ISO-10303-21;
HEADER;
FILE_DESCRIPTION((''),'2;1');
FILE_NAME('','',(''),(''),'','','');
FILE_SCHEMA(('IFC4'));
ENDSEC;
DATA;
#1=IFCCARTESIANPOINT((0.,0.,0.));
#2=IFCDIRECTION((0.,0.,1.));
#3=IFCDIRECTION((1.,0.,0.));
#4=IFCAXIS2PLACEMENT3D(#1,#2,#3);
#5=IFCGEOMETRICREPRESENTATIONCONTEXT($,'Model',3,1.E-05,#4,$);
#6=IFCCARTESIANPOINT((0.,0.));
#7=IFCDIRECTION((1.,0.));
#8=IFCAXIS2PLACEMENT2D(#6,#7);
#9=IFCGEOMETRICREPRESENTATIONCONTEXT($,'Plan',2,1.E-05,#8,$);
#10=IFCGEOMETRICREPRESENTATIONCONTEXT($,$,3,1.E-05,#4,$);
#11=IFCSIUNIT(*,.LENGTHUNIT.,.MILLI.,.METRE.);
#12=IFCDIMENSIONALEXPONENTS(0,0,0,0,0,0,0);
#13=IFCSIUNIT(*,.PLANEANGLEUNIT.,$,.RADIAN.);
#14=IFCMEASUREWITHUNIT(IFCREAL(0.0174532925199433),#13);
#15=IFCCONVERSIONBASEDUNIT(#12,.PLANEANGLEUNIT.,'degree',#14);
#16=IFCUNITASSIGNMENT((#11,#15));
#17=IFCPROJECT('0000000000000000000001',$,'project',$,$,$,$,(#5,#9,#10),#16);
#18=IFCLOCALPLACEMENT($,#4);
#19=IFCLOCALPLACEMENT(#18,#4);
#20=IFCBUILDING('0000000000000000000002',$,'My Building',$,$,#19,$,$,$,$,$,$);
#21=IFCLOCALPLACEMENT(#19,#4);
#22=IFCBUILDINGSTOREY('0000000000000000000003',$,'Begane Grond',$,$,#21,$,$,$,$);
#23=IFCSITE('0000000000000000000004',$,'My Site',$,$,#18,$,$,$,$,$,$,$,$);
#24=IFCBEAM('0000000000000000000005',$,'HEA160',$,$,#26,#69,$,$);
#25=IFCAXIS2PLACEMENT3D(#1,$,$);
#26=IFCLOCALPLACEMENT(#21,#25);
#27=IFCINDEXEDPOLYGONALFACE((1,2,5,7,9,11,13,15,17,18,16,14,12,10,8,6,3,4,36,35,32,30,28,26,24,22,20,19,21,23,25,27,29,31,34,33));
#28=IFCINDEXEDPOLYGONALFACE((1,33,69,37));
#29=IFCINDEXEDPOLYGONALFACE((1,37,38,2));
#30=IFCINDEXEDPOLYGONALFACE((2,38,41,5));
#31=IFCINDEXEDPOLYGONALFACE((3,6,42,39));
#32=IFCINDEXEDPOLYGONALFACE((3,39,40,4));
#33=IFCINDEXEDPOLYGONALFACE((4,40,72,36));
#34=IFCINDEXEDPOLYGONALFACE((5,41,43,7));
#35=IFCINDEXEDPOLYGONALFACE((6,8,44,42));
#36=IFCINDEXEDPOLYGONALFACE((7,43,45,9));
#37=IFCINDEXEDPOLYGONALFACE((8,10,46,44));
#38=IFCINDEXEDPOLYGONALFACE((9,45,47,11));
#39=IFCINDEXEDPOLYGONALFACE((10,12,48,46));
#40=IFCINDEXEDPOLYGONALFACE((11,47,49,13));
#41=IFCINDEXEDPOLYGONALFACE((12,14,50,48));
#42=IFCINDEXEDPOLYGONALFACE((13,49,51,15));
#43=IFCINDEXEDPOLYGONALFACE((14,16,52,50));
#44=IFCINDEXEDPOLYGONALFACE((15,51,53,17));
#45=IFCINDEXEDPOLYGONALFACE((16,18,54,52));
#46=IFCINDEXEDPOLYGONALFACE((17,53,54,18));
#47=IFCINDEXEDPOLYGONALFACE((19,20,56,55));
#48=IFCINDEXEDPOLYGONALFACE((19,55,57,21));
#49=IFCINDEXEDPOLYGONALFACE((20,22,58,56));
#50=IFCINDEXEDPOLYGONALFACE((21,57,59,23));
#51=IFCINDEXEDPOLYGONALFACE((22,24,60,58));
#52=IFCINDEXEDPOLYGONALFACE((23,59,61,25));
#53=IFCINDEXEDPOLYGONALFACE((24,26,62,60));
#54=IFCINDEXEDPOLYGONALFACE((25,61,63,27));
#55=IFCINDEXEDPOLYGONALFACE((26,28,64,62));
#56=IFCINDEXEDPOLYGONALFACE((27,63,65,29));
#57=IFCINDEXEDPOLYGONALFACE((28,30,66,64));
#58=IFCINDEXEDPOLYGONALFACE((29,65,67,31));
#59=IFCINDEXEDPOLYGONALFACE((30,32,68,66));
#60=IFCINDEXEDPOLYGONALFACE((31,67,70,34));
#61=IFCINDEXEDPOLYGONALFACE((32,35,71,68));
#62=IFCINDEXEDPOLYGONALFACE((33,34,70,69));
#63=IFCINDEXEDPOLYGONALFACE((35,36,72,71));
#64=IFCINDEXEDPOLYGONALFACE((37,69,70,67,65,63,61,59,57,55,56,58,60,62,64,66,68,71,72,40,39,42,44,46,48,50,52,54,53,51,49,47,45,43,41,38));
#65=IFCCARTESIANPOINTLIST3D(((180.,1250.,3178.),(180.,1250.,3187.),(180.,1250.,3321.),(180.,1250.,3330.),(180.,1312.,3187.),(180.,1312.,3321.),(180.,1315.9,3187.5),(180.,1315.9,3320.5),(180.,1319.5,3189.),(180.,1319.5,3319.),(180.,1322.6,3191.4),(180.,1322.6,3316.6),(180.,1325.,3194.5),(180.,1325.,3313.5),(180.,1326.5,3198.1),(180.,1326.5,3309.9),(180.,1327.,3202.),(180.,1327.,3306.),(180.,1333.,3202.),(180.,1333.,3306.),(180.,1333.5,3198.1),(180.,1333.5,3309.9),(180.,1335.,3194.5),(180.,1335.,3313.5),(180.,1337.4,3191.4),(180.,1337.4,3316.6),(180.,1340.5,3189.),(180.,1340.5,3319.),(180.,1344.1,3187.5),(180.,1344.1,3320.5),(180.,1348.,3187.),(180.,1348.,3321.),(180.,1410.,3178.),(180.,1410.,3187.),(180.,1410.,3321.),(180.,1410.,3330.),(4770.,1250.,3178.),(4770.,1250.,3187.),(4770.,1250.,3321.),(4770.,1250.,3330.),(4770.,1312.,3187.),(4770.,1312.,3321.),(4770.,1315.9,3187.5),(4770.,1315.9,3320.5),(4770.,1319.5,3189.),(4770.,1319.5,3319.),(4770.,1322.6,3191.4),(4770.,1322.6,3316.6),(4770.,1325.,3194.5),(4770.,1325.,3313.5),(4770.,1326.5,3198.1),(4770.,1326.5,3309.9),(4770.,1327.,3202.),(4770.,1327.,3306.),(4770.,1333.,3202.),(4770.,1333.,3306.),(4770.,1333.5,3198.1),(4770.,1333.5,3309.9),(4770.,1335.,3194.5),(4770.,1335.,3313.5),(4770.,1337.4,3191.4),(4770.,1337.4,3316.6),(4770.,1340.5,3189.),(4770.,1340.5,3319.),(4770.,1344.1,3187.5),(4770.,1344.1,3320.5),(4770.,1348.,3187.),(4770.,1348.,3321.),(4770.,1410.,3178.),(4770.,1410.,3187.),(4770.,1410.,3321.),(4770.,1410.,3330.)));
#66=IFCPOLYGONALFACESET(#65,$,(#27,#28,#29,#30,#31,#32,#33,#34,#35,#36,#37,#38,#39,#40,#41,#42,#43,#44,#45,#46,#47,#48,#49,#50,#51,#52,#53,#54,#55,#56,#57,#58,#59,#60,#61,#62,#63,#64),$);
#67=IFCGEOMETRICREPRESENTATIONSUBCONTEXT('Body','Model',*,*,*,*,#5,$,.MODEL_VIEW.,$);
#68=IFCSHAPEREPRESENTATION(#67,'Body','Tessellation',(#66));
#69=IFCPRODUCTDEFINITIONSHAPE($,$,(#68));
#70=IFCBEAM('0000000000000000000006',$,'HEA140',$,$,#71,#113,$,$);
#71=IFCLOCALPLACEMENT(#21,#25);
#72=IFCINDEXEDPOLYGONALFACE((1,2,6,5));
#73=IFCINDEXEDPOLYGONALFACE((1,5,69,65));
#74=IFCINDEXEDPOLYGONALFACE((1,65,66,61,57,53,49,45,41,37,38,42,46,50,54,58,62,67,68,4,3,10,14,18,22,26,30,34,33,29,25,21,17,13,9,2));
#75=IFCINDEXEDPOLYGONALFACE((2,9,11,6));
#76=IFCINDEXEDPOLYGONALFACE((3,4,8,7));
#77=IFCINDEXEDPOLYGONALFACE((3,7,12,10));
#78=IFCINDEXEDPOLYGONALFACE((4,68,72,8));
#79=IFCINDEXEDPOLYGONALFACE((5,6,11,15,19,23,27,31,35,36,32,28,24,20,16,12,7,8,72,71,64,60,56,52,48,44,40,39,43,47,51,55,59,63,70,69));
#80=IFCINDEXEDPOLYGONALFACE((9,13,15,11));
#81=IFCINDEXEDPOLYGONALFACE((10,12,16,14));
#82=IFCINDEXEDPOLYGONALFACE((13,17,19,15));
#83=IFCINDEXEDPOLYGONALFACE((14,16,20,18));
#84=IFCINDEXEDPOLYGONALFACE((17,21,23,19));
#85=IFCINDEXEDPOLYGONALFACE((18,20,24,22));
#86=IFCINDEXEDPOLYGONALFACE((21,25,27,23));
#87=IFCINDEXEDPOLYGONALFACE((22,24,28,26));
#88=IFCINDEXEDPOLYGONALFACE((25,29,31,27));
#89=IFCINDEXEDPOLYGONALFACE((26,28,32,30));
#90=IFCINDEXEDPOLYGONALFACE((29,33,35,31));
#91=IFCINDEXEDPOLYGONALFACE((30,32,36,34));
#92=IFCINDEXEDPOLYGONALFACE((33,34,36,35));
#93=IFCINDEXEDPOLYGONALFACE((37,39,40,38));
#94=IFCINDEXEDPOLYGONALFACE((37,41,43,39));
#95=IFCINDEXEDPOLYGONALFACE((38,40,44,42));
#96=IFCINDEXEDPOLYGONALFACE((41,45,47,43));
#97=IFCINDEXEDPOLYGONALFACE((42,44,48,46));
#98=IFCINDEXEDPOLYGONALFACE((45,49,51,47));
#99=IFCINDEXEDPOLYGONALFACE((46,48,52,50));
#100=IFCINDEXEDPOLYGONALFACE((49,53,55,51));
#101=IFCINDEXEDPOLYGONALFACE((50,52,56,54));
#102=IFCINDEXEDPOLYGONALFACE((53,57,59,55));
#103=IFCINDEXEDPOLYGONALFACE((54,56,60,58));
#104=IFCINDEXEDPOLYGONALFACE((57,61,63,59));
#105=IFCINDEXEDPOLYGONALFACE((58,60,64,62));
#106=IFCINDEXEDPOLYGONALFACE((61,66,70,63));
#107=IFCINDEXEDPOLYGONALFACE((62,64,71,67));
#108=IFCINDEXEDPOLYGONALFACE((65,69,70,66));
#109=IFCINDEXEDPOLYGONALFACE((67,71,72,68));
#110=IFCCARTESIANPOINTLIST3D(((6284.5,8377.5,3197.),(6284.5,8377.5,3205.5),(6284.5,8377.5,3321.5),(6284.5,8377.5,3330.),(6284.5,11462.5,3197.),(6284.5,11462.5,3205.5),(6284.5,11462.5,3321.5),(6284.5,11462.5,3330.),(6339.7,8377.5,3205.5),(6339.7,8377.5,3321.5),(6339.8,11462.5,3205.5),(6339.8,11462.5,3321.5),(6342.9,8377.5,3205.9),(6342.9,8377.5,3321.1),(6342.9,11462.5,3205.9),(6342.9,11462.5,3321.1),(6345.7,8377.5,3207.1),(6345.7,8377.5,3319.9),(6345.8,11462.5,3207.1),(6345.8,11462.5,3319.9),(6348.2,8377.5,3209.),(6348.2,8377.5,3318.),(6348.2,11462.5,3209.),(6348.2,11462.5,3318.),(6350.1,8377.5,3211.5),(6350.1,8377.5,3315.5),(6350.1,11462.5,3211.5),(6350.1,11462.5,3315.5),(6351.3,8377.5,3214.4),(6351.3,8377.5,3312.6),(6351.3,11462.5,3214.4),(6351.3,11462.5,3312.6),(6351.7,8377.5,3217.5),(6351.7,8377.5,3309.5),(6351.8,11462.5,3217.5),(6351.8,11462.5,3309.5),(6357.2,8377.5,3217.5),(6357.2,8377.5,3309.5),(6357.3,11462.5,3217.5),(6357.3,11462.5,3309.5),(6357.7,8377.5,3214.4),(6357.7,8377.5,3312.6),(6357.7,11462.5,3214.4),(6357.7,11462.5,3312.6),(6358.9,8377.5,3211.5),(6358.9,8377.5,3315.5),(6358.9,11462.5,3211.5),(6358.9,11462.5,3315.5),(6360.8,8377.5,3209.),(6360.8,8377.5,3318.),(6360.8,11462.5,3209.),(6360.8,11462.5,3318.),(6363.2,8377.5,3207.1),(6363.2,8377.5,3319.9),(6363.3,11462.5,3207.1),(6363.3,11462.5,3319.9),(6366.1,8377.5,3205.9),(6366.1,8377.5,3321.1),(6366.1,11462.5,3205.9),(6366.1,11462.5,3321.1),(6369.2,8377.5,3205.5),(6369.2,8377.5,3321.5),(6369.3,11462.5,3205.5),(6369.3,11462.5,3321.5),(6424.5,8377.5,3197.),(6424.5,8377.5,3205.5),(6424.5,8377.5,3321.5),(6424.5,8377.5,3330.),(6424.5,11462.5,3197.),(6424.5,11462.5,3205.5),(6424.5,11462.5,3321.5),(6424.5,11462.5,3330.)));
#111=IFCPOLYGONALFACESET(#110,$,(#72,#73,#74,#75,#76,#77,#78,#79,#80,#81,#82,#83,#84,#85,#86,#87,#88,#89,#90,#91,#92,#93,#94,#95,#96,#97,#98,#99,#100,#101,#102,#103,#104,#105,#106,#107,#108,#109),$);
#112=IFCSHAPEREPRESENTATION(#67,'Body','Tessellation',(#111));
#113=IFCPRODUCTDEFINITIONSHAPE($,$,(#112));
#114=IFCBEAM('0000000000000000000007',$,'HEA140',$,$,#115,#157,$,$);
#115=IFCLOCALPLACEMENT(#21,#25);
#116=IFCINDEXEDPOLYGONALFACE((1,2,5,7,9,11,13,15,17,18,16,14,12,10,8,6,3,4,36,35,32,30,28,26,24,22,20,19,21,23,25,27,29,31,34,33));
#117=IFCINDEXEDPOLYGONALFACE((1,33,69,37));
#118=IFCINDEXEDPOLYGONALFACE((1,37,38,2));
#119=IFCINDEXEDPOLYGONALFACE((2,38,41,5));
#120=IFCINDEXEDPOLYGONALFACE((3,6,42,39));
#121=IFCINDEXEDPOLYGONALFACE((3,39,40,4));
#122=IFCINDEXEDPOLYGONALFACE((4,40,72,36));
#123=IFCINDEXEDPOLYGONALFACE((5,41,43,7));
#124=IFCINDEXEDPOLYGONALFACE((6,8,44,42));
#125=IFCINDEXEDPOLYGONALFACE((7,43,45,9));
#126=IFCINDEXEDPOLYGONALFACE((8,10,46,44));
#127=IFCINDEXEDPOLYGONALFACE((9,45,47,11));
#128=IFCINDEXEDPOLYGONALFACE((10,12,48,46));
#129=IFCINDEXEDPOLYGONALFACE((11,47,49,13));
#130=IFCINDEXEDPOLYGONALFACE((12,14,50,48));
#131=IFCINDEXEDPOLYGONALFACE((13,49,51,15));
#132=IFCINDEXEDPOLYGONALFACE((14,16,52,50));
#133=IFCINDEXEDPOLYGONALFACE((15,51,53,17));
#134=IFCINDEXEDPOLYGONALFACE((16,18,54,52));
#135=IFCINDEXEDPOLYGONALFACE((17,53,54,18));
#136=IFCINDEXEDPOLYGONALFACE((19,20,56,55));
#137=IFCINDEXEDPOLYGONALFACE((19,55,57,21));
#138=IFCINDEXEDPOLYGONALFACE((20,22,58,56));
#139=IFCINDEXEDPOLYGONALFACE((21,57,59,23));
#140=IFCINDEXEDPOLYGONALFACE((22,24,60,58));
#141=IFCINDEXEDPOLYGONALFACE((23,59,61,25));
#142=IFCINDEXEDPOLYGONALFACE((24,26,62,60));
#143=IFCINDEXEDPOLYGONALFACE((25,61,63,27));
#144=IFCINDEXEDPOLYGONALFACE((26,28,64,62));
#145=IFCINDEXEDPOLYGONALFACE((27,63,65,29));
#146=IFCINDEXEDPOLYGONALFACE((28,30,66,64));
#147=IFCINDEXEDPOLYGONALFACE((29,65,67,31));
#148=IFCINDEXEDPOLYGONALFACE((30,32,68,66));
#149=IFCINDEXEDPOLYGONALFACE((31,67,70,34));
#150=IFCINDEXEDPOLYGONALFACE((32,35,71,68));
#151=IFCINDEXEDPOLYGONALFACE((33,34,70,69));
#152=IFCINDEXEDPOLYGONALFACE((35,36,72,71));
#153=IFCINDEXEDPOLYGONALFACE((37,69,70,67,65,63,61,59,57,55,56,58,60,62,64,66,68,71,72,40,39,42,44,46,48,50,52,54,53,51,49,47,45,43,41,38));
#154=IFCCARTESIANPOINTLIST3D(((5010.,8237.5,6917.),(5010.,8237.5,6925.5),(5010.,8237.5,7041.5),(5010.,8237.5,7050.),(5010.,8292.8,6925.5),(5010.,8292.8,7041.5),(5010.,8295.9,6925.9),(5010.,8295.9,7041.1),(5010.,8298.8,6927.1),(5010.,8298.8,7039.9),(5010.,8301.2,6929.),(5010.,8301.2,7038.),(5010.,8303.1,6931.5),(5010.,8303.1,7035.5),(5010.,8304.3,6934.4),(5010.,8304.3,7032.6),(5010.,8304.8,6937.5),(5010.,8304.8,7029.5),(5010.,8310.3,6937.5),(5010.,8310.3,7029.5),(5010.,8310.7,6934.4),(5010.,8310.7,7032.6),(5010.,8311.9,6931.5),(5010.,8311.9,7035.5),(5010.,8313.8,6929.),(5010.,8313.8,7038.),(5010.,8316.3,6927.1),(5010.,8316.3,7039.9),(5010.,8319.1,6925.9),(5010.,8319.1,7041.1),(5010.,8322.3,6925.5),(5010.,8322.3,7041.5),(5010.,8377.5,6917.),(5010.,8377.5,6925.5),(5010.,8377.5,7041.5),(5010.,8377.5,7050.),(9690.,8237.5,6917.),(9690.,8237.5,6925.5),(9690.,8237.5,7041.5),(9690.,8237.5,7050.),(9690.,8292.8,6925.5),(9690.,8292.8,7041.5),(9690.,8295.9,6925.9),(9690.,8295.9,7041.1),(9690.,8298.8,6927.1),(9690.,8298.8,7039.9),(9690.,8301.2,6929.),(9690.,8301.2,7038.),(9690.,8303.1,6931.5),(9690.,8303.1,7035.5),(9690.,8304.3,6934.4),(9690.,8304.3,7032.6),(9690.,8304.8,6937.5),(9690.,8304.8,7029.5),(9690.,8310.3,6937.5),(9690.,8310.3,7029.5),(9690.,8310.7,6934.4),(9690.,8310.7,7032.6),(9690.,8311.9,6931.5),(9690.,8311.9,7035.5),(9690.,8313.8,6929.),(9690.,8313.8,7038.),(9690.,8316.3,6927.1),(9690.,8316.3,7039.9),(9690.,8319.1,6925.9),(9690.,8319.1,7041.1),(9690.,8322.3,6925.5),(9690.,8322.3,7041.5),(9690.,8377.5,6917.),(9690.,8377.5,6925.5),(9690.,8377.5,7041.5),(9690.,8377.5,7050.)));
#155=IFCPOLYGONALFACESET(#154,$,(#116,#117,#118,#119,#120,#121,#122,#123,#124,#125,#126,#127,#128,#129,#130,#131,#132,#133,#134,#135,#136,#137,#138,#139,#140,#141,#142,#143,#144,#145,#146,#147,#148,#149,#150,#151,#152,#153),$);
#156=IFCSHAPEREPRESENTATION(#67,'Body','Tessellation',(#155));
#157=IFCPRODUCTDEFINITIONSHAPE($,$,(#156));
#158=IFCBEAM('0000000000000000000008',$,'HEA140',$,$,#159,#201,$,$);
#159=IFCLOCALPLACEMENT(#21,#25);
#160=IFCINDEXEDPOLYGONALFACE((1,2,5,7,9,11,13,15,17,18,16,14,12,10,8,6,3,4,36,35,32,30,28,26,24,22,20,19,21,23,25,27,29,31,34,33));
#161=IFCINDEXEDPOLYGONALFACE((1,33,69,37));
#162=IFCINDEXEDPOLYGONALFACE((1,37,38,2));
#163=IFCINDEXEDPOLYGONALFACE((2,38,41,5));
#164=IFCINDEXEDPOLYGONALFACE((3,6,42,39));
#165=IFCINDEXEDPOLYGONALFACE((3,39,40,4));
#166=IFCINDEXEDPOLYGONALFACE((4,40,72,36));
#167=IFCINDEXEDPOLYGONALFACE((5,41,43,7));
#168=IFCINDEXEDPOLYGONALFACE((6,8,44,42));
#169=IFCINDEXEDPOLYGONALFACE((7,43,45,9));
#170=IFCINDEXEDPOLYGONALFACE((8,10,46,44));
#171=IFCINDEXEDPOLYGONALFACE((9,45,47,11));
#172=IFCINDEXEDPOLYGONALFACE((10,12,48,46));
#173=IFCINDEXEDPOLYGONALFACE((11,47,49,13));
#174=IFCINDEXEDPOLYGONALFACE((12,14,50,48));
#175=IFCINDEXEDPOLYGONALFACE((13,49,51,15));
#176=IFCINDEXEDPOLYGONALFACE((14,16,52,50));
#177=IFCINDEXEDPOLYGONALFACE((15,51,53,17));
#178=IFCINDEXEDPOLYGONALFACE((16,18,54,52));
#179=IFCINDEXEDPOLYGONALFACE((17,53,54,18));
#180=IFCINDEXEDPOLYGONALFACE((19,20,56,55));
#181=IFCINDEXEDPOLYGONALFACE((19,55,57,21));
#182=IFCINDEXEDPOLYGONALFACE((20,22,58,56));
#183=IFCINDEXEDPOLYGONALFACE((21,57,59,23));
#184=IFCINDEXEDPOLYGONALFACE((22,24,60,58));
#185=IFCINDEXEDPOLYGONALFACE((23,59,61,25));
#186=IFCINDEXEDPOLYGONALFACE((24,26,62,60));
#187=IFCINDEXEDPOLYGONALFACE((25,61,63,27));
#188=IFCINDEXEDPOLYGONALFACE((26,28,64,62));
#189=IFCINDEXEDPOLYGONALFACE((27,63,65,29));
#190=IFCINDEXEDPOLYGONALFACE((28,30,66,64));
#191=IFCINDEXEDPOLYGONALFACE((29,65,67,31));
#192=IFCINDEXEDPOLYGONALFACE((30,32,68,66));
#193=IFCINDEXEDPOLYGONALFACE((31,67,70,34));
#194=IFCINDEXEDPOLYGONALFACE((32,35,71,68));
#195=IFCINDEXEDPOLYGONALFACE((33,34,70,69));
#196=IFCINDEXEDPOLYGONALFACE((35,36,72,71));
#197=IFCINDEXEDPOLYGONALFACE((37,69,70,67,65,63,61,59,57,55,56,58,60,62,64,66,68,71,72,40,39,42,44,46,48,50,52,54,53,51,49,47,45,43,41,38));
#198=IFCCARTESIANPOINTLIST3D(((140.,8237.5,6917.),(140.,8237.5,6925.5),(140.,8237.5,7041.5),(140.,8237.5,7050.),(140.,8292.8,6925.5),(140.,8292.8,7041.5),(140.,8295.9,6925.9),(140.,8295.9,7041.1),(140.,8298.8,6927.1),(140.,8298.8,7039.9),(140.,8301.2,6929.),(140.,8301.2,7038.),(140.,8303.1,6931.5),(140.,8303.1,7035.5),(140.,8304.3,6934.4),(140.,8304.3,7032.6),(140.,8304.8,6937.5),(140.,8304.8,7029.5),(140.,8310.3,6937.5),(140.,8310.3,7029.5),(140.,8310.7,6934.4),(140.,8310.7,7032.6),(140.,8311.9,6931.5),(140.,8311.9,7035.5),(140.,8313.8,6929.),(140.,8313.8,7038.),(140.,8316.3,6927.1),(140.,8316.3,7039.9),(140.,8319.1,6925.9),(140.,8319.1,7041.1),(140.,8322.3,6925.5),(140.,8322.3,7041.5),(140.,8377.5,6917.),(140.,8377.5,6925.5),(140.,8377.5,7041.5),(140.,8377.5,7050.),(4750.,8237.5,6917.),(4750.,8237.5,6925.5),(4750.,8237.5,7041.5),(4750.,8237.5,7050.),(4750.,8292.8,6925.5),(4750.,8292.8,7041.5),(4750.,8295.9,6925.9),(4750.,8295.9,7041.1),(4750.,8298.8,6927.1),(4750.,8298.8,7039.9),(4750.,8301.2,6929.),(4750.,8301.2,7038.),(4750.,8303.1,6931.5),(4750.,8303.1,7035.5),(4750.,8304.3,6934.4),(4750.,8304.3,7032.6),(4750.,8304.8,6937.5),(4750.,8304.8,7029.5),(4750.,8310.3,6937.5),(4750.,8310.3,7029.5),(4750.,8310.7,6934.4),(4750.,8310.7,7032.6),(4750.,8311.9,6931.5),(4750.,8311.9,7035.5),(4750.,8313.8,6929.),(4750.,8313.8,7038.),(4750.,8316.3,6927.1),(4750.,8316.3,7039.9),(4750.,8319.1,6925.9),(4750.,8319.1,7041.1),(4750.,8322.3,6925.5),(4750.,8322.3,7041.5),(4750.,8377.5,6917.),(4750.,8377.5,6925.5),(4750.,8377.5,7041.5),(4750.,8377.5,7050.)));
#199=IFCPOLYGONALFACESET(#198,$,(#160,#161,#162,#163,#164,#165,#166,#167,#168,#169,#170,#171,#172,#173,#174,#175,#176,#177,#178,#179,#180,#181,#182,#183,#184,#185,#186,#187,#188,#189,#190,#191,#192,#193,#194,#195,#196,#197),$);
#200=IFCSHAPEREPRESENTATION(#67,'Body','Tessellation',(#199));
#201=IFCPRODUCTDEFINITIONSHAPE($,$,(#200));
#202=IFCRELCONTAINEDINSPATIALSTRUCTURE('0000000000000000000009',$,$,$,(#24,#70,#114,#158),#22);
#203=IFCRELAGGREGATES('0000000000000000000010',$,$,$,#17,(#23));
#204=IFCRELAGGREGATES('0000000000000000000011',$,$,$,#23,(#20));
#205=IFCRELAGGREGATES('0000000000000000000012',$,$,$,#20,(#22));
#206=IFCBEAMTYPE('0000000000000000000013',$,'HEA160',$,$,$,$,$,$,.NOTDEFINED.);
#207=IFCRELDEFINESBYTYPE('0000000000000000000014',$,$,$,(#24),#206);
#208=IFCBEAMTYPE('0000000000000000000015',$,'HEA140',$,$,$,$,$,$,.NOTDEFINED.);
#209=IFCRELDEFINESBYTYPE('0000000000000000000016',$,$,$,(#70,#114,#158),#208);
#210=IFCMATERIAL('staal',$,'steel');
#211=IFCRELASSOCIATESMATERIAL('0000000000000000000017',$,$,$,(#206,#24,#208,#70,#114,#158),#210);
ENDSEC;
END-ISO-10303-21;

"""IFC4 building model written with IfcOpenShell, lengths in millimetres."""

from ifc_helpers import new_model, entity, si_unit, converted_unit, frame, origin_with_axes, origin_2d_with_axis, place, context, subcontext, project, spatial, i_section, extrude, material, material_profile, profile_set, profile_usage, type_object, element, save


model = new_model("IFC4")

# Units and contexts
model_context = context("Model", 3, precision=1e-05, world=origin_with_axes())
plan_context = context("Plan", 2, precision=1e-05, world=origin_2d_with_axis())
context_of_model = context(None, 3, precision=1e-05, world=origin_with_axes())
body_context = subcontext(model_context, "Body", "Model", "MODEL_VIEW")
ifc_project = project(units=[si_unit("LENGTHUNIT", "METRE", prefix="MILLI"), converted_unit("PLANEANGLEUNIT", "degree", entity("IfcReal", 0.0174532925199433), si_unit("PLANEANGLEUNIT", "RADIAN"), dimensions=[0, 0, 0, 0, 0, 0, 0])], contexts=[model_context, plan_context, context_of_model])

# Site, building, storey
site_placement = place(None, origin_with_axes())
site = spatial("IfcSite", under=ifc_project, at=site_placement, Name="My Site")
building_placement = place(site_placement, origin_with_axes())
building = spatial("IfcBuilding", under=site, at=building_placement, Name="My Building")
storey_placement = place(building_placement, origin_with_axes())
storey = spatial("IfcBuildingStorey", under=building, at=storey_placement, Name="Begane Grond")

# Shared definitions
ifc_material = material(Name="staal", Category="steel")

# Beams
ifc_material_profile_1 = material_profile(ifc_material, i_section(OverallWidth=160.0, OverallDepth=152.0, WebThickness=6.0, FlangeThickness=9.0, FilletRadius=15.0))
ifc_profile_set_1 = profile_set([ifc_material_profile_1], Name="HEA160")
ifc_profile_usage_1 = profile_usage(ifc_profile_set_1, cardinal=5)
beam_type_1 = type_object("IfcBeamType", Name="HEA160", PredefinedType="NOTDEFINED", material=ifc_profile_set_1)
beam_1_placement = place(storey_placement, frame((180.0, 1330.0, 3254.0), z_axis=(1.0, 0.0, 0.0), x_axis=(0.0, 1.0, 0.0)))
element("IfcBeam", 1, at=beam_1_placement, inside=storey, type_object=beam_type_1, material=ifc_profile_usage_1, Name="HEA160", context=body_context, shape_type="SweptSolid", body=[
    extrude(i_section(OverallWidth=160.0, OverallDepth=152.0, WebThickness=6.0, FlangeThickness=9.0, FilletRadius=15.0), origin_with_axes(), (0.0, 0.0, 1.0), 4590.0),
])
ifc_material_profile_2 = material_profile(ifc_material, i_section(OverallWidth=140.0, OverallDepth=133.0, WebThickness=5.5, FlangeThickness=8.5, FilletRadius=12.0))
ifc_profile_set_2 = profile_set([ifc_material_profile_2], Name="HEA140")
ifc_profile_usage_2 = profile_usage(ifc_profile_set_2)
beam_type_2 = type_object("IfcBeamType", Name="HEA140", PredefinedType="NOTDEFINED", material=ifc_profile_set_2)
beam_2_placement = place(storey_placement, frame((6354.5, 8377.5, 3263.5), z_axis=(0.0, 1.0, 0.0), x_axis=(-1.0, 0.0, 0.0)))
element("IfcBeam", 2, at=beam_2_placement, inside=storey, type_object=beam_type_2, material=ifc_profile_usage_2, Name="HEA140", context=body_context, shape_type="SweptSolid", body=[
    extrude(i_section(OverallWidth=140.0, OverallDepth=133.0, WebThickness=5.5, FlangeThickness=8.5, FilletRadius=12.0), origin_with_axes(), (0.0, 0.0, 1.0), 3085.0),
])
ifc_profile_usage_3 = profile_usage(ifc_profile_set_2)
beam_3_placement = place(storey_placement, frame((9690.0, 8307.5, 6983.5), z_axis=(-1.0, 0.0, 0.0), x_axis=(0.0, -1.0, 0.0)))
element("IfcBeam", 3, at=beam_3_placement, inside=storey, type_object=beam_type_2, material=ifc_profile_usage_3, Name="HEA140", context=body_context, shape_type="SweptSolid", body=[
    extrude(i_section(OverallWidth=140.0, OverallDepth=133.0, WebThickness=5.5, FlangeThickness=8.5, FilletRadius=12.0), origin_with_axes(), (0.0, 0.0, 1.0), 4680.0),
])
ifc_profile_usage_4 = profile_usage(ifc_profile_set_2)
beam_4_placement = place(storey_placement, frame((4750.0, 8307.5, 6983.5), z_axis=(-1.0, 0.0, 0.0), x_axis=(0.0, -1.0, 0.0)))
element("IfcBeam", 4, at=beam_4_placement, inside=storey, type_object=beam_type_2, material=ifc_profile_usage_4, Name="HEA140", context=body_context, shape_type="SweptSolid", body=[
    extrude(i_section(OverallWidth=140.0, OverallDepth=133.0, WebThickness=5.5, FlangeThickness=8.5, FilletRadius=12.0), origin_with_axes(), (0.0, 0.0, 1.0), 4610.0),
])

save(model, "model.ifc")
